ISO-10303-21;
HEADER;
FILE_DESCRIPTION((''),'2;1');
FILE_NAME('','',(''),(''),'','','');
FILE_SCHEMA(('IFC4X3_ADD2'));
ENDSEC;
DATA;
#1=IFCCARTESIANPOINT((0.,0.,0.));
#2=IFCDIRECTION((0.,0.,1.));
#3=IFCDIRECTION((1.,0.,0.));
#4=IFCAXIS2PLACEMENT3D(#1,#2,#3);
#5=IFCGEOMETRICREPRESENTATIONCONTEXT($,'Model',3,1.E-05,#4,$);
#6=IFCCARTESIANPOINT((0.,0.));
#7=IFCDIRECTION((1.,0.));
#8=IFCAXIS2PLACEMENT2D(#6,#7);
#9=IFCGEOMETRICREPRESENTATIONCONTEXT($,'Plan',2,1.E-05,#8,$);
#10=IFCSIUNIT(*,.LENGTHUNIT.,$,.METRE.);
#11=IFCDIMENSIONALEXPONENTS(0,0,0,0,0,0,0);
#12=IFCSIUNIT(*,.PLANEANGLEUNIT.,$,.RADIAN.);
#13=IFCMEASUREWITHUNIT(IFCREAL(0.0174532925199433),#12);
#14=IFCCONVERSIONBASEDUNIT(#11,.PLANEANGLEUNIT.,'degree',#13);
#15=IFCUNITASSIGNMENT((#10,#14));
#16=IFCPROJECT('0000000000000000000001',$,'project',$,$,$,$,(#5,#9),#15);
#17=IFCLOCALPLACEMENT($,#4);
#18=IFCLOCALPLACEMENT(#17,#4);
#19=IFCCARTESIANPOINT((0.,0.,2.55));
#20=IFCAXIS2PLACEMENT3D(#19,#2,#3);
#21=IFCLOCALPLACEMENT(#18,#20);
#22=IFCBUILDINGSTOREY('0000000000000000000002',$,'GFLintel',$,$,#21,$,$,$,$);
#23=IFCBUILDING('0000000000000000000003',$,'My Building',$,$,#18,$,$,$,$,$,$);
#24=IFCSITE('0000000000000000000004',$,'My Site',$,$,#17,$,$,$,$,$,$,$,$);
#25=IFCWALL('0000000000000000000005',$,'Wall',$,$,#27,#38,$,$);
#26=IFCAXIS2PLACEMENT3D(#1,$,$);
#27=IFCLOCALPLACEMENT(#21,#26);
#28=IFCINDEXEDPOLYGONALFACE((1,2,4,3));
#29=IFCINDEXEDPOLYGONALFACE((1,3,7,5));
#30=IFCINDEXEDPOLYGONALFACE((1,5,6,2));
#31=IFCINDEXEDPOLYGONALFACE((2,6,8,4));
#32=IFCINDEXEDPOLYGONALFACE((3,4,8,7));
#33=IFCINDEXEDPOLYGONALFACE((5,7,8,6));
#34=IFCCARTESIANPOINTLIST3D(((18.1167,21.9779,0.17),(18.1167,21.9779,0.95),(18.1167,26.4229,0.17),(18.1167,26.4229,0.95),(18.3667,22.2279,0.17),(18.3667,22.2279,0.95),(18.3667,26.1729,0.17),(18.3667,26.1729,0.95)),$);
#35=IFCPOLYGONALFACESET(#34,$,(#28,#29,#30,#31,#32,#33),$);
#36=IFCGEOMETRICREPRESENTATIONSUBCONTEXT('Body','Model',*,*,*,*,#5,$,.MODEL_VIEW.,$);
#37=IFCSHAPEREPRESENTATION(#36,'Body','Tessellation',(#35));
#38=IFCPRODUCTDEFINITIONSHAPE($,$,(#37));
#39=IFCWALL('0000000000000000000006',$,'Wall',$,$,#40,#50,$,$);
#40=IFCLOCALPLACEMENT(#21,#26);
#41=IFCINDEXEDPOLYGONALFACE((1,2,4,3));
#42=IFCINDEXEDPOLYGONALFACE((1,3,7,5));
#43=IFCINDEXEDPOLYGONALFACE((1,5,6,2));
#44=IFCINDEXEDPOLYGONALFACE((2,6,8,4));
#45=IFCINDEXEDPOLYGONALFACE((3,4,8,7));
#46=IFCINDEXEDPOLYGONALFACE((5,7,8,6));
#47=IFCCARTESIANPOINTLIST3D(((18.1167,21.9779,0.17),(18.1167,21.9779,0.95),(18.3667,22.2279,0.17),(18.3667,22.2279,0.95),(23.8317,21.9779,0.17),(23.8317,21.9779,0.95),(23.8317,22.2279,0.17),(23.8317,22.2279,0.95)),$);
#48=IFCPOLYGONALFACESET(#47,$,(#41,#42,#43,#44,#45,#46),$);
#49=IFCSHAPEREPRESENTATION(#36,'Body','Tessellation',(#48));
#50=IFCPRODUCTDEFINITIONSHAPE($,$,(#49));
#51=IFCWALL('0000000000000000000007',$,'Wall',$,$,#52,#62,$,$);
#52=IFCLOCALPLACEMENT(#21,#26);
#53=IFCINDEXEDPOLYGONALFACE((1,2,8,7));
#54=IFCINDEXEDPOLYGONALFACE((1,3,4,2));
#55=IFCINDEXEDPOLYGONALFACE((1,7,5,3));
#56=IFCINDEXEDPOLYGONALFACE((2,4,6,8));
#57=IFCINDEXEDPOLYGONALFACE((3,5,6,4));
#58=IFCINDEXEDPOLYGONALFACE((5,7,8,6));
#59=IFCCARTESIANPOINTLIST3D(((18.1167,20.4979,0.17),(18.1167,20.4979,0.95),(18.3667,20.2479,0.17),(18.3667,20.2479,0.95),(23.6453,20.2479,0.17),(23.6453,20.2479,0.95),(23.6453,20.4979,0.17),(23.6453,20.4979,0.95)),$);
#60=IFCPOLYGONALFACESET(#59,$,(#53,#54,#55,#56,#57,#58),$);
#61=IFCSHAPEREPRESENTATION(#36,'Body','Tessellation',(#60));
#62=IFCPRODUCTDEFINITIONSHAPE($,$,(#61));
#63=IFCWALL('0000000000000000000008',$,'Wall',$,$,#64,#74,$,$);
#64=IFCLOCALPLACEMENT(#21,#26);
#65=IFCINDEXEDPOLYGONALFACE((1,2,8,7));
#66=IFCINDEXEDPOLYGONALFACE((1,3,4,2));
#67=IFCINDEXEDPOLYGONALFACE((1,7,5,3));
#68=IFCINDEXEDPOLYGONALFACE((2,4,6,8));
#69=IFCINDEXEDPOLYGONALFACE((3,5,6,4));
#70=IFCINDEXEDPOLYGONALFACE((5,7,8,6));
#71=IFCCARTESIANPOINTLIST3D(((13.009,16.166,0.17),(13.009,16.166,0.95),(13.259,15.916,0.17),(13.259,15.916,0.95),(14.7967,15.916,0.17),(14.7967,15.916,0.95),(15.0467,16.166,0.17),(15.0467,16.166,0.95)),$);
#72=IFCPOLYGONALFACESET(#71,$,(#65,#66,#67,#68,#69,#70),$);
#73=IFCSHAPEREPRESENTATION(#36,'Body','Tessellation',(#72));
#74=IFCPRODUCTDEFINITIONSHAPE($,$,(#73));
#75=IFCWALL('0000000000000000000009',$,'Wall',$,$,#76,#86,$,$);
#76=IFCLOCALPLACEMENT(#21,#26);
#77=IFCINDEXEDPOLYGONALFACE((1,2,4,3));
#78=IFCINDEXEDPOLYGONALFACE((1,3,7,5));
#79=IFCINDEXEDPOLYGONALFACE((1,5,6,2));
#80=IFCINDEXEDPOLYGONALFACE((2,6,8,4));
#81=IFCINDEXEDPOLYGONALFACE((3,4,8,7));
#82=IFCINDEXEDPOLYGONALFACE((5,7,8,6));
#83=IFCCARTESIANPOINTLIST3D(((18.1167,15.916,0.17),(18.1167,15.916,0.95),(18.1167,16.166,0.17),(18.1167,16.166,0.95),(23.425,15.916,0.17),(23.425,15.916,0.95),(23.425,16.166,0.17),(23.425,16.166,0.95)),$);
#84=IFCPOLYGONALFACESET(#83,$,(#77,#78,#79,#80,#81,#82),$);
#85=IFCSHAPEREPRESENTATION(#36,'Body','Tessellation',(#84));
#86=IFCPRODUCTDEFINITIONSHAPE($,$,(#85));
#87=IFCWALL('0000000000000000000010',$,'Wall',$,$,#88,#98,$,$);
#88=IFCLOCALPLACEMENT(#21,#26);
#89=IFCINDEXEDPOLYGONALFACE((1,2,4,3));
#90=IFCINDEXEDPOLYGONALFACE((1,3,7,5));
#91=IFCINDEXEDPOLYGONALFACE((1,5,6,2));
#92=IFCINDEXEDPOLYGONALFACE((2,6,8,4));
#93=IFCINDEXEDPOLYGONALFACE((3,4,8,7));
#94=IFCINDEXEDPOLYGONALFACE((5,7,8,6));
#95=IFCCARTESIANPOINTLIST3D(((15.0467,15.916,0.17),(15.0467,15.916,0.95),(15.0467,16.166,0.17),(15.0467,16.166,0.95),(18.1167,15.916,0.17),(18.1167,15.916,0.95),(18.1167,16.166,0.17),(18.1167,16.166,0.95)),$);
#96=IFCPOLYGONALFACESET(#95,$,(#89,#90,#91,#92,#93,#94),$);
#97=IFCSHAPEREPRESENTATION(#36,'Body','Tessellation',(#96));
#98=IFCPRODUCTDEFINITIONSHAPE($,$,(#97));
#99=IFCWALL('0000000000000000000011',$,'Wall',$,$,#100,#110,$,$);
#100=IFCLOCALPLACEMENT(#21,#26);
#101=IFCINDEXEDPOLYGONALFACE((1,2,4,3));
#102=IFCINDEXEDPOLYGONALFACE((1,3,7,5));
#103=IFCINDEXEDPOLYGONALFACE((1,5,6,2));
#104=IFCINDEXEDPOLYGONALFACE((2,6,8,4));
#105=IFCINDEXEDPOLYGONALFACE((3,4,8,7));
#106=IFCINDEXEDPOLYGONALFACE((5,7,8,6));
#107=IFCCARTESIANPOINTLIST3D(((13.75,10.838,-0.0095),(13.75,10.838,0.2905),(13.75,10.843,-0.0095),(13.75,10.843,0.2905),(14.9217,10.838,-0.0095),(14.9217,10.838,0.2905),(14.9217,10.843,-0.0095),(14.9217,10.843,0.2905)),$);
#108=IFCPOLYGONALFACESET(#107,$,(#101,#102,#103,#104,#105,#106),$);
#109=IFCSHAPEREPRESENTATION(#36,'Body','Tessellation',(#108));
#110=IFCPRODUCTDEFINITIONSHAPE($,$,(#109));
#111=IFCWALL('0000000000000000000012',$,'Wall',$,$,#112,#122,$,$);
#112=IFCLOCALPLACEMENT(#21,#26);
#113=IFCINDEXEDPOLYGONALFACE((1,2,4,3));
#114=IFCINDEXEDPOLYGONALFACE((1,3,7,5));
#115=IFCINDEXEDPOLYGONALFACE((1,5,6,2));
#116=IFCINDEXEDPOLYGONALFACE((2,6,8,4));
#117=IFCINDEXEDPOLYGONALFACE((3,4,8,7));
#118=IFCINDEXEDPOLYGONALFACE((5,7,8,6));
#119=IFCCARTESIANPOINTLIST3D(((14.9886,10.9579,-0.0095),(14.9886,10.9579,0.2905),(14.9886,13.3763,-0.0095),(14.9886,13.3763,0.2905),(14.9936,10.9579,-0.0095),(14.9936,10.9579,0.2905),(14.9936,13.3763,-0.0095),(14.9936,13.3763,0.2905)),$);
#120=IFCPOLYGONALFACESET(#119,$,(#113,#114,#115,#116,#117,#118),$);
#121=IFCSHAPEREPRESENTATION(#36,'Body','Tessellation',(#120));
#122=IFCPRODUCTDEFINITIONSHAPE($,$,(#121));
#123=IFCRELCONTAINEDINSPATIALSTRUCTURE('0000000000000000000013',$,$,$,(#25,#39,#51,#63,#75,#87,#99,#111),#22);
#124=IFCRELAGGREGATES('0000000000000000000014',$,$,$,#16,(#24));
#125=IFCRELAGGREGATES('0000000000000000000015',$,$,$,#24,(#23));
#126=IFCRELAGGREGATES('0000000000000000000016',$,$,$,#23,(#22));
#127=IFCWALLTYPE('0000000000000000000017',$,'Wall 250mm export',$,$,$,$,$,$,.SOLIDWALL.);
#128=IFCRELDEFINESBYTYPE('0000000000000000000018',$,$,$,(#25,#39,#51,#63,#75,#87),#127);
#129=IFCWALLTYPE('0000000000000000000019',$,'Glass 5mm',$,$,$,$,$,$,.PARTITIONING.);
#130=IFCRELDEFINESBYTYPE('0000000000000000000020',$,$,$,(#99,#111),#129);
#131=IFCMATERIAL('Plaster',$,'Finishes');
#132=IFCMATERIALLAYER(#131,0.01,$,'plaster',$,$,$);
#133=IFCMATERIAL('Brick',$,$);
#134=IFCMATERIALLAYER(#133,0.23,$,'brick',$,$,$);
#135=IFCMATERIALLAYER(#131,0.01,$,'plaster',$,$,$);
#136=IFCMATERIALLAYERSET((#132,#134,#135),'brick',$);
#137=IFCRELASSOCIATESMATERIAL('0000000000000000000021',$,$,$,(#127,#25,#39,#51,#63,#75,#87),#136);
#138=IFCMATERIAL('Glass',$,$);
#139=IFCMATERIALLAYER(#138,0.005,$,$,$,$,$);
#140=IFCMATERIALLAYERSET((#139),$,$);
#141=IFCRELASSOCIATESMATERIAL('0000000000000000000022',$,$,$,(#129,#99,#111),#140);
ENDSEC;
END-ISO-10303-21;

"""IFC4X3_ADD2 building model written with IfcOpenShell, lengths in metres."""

from ifc_helpers import new_model, entity, si_unit, converted_unit, frame, origin_with_axes, origin_2d_with_axis, place, context, subcontext, project, spatial, line, indexed_curve, outline, extrude, material, layer, layer_set, layer_usage, type_object, element, save


model = new_model("IFC4X3_ADD2")

# Units and contexts
model_context = context("Model", 3, precision=1e-05, world=origin_with_axes())
plan_context = context("Plan", 2, precision=1e-05, world=origin_2d_with_axis())
body_context = subcontext(model_context, "Body", "Model", "MODEL_VIEW")
ifc_project = project(units=[si_unit("LENGTHUNIT", "METRE"), converted_unit("PLANEANGLEUNIT", "degree", entity("IfcReal", 0.0174532925199433), si_unit("PLANEANGLEUNIT", "RADIAN"), dimensions=[0, 0, 0, 0, 0, 0, 0])], contexts=[model_context, plan_context])

# Site, building, storey
site_placement = place(None, origin_with_axes())
site = spatial("IfcSite", under=ifc_project, at=site_placement, Name="My Site")
building_placement = place(site_placement, origin_with_axes())
building = spatial("IfcBuilding", under=site, at=building_placement, Name="My Building")
storey_placement = place(building_placement, frame((0.0, 0.0, 2.55), z_axis=(0.0, 0.0, 1.0), x_axis=(1.0, 0.0, 0.0)))
storey = spatial("IfcBuildingStorey", under=building, at=storey_placement, Name="GFLintel")

# Shared definitions
ifc_material_1 = material(Name="Glass")

# Walls
ifc_material_2 = material(Name="Plaster", Category="Finishes")
ifc_layer_1 = layer(ifc_material_2, 0.01, Name="plaster")
ifc_material_3 = material(Name="Brick")
ifc_layer_2 = layer(ifc_material_3, 0.23, Name="brick")
ifc_layer_3 = layer(ifc_material_2, 0.01, Name="plaster")
ifc_layer_set_1 = layer_set([ifc_layer_1, ifc_layer_2, ifc_layer_3], Name="brick")
wall_type_1 = type_object("IfcWallType", Name="Wall 250mm export", PredefinedType="SOLIDWALL", material=ifc_layer_set_1)
ifc_layer_usage_1 = layer_usage(ifc_layer_set_1, "AXIS2", "POSITIVE", 0.0)
wall_1_placement = place(storey_placement, frame((18.3667, 21.9779, 0.17), z_axis=(0.0, 0.0, 1.0), x_axis=(0.0, 1.0, 0.0)))
element("IfcWall", 1, at=wall_1_placement, inside=storey, type_object=wall_type_1, material=ifc_layer_usage_1, Name="Wall", context=body_context, shape_type="SweptSolid", body=[
    extrude(outline(indexed_curve([(0.25, 0.0), (0.0, 0.25), (4.445, 0.25), (4.195, 0.0)], segments=[line(1, 2, 3, 4, 1)])), origin_with_axes(), (0.0, 0.0, 1.0), 0.78),
])
ifc_layer_usage_2 = layer_usage(ifc_layer_set_1, "AXIS2", "POSITIVE", 0.0)
wall_2_placement = place(storey_placement, frame((18.3667, 21.9779, 0.17), z_axis=(0.0, 0.0, 1.0), x_axis=(1.0, 0.0, 0.0)))
element("IfcWall", 2, at=wall_2_placement, inside=storey, type_object=wall_type_1, material=ifc_layer_usage_2, Name="Wall", context=body_context, shape_type="SweptSolid", body=[
    extrude(outline(indexed_curve([(-0.25, 0.0), (0.0, 0.25), (5.465, 0.25), (5.465, 0.0)], segments=[line(1, 2, 3, 4, 1)])), origin_with_axes(), (0.0, 0.0, 1.0), 0.78),
])
ifc_layer_usage_3 = layer_usage(ifc_layer_set_1, "AXIS2", "POSITIVE", 0.0)
wall_3_placement = place(storey_placement, frame((18.1167, 20.2479, 0.17), z_axis=(0.0, 0.0, 1.0), x_axis=(1.0, 0.0, 0.0)))
element("IfcWall", 3, at=wall_3_placement, inside=storey, type_object=wall_type_1, material=ifc_layer_usage_3, Name="Wall", context=body_context, shape_type="SweptSolid", body=[
    extrude(outline(indexed_curve([(0.25, 0.0), (0.0, 0.25), (5.5286, 0.25), (5.5286, 0.0)], segments=[line(1, 2, 3, 4, 1)])), origin_with_axes(), (0.0, 0.0, 1.0), 0.78),
])
ifc_layer_usage_4 = layer_usage(ifc_layer_set_1, "AXIS2", "POSITIVE", 0.0)
wall_4_placement = place(storey_placement, frame((13.259, 15.916, 0.17), z_axis=(0.0, 0.0, 1.0), x_axis=(1.0, 0.0, 0.0)))
element("IfcWall", 4, at=wall_4_placement, inside=storey, type_object=wall_type_1, material=ifc_layer_usage_4, Name="Wall", context=body_context, shape_type="SweptSolid", body=[
    extrude(outline(indexed_curve([(0.0, 0.0), (-0.25, 0.25), (1.7877, 0.25), (1.5377, 0.0)], segments=[line(1, 2, 3, 4, 1)])), origin_with_axes(), (0.0, 0.0, 1.0), 0.78),
])
ifc_layer_usage_5 = layer_usage(ifc_layer_set_1, "AXIS2", "POSITIVE", 0.0)
wall_5_placement = place(storey_placement, frame((18.1167, 15.916, 0.17), z_axis=(0.0, 0.0, 1.0), x_axis=(1.0, 0.0, 0.0)))
element("IfcWall", 5, at=wall_5_placement, inside=storey, type_object=wall_type_1, material=ifc_layer_usage_5, Name="Wall", context=body_context, shape_type="SweptSolid", body=[
    extrude(outline(indexed_curve([(0.0, 0.0), (0.0, 0.25), (5.3083, 0.25), (5.3083, 0.0)], segments=[line(1, 2, 3, 4, 1)])), origin_with_axes(), (0.0, 0.0, 1.0), 0.78),
])
ifc_layer_usage_6 = layer_usage(ifc_layer_set_1, "AXIS2", "POSITIVE", 0.0)
wall_6_placement = place(storey_placement, frame((15.0467, 15.916, 0.17), z_axis=(0.0, 0.0, 1.0), x_axis=(1.0, 0.0, 0.0)))
element("IfcWall", 6, at=wall_6_placement, inside=storey, type_object=wall_type_1, material=ifc_layer_usage_6, Name="Wall", context=body_context, shape_type="SweptSolid", body=[
    extrude(outline(indexed_curve([(0.0, 0.0), (0.0, 0.25), (3.07, 0.25), (3.07, 0.0)], segments=[line(1, 2, 3, 4, 1)])), origin_with_axes(), (0.0, 0.0, 1.0), 0.78),
])
ifc_layer_4 = layer(ifc_material_1, 0.005)
ifc_layer_set_2 = layer_set([ifc_layer_4])
ifc_layer_usage_7 = layer_usage(ifc_layer_set_2, "AXIS2", "POSITIVE", 0.0)
wall_type_2 = type_object("IfcWallType", Name="Glass 5mm", PredefinedType="PARTITIONING", material=ifc_layer_set_2)
wall_7_placement = place(storey_placement, frame((13.75, 10.838, -0.0095), z_axis=(0.0, 0.0, 1.0), x_axis=(1.0, 0.0, 0.0)))
element("IfcWall", 7, at=wall_7_placement, inside=storey, type_object=wall_type_2, material=ifc_layer_usage_7, Name="Wall", context=body_context, shape_type="SweptSolid", body=[
    extrude(outline(indexed_curve([(0.0, 0.0), (0.0, 0.005), (1.1717, 0.005), (1.1717, 0.0)], segments=[line(1, 2, 3, 4, 1)])), origin_with_axes(), (0.0, 0.0, 1.0), 0.3),
])
ifc_layer_usage_8 = layer_usage(ifc_layer_set_2, "AXIS2", "POSITIVE", 0.0)
wall_8_placement = place(storey_placement, frame((14.9936, 10.9579, -0.0095), z_axis=(0.0, 0.0, 1.0), x_axis=(0.0, 1.0, 0.0)))
element("IfcWall", 8, at=wall_8_placement, inside=storey, type_object=wall_type_2, material=ifc_layer_usage_8, Name="Wall", context=body_context, shape_type="SweptSolid", body=[
    extrude(outline(indexed_curve([(0.0, 0.0), (0.0, 0.005), (2.4184, 0.005), (2.4184, 0.0)], segments=[line(1, 2, 3, 4, 1)])), origin_with_axes(), (0.0, 0.0, 1.0), 0.3),
])

save(model, "model.ifc")
